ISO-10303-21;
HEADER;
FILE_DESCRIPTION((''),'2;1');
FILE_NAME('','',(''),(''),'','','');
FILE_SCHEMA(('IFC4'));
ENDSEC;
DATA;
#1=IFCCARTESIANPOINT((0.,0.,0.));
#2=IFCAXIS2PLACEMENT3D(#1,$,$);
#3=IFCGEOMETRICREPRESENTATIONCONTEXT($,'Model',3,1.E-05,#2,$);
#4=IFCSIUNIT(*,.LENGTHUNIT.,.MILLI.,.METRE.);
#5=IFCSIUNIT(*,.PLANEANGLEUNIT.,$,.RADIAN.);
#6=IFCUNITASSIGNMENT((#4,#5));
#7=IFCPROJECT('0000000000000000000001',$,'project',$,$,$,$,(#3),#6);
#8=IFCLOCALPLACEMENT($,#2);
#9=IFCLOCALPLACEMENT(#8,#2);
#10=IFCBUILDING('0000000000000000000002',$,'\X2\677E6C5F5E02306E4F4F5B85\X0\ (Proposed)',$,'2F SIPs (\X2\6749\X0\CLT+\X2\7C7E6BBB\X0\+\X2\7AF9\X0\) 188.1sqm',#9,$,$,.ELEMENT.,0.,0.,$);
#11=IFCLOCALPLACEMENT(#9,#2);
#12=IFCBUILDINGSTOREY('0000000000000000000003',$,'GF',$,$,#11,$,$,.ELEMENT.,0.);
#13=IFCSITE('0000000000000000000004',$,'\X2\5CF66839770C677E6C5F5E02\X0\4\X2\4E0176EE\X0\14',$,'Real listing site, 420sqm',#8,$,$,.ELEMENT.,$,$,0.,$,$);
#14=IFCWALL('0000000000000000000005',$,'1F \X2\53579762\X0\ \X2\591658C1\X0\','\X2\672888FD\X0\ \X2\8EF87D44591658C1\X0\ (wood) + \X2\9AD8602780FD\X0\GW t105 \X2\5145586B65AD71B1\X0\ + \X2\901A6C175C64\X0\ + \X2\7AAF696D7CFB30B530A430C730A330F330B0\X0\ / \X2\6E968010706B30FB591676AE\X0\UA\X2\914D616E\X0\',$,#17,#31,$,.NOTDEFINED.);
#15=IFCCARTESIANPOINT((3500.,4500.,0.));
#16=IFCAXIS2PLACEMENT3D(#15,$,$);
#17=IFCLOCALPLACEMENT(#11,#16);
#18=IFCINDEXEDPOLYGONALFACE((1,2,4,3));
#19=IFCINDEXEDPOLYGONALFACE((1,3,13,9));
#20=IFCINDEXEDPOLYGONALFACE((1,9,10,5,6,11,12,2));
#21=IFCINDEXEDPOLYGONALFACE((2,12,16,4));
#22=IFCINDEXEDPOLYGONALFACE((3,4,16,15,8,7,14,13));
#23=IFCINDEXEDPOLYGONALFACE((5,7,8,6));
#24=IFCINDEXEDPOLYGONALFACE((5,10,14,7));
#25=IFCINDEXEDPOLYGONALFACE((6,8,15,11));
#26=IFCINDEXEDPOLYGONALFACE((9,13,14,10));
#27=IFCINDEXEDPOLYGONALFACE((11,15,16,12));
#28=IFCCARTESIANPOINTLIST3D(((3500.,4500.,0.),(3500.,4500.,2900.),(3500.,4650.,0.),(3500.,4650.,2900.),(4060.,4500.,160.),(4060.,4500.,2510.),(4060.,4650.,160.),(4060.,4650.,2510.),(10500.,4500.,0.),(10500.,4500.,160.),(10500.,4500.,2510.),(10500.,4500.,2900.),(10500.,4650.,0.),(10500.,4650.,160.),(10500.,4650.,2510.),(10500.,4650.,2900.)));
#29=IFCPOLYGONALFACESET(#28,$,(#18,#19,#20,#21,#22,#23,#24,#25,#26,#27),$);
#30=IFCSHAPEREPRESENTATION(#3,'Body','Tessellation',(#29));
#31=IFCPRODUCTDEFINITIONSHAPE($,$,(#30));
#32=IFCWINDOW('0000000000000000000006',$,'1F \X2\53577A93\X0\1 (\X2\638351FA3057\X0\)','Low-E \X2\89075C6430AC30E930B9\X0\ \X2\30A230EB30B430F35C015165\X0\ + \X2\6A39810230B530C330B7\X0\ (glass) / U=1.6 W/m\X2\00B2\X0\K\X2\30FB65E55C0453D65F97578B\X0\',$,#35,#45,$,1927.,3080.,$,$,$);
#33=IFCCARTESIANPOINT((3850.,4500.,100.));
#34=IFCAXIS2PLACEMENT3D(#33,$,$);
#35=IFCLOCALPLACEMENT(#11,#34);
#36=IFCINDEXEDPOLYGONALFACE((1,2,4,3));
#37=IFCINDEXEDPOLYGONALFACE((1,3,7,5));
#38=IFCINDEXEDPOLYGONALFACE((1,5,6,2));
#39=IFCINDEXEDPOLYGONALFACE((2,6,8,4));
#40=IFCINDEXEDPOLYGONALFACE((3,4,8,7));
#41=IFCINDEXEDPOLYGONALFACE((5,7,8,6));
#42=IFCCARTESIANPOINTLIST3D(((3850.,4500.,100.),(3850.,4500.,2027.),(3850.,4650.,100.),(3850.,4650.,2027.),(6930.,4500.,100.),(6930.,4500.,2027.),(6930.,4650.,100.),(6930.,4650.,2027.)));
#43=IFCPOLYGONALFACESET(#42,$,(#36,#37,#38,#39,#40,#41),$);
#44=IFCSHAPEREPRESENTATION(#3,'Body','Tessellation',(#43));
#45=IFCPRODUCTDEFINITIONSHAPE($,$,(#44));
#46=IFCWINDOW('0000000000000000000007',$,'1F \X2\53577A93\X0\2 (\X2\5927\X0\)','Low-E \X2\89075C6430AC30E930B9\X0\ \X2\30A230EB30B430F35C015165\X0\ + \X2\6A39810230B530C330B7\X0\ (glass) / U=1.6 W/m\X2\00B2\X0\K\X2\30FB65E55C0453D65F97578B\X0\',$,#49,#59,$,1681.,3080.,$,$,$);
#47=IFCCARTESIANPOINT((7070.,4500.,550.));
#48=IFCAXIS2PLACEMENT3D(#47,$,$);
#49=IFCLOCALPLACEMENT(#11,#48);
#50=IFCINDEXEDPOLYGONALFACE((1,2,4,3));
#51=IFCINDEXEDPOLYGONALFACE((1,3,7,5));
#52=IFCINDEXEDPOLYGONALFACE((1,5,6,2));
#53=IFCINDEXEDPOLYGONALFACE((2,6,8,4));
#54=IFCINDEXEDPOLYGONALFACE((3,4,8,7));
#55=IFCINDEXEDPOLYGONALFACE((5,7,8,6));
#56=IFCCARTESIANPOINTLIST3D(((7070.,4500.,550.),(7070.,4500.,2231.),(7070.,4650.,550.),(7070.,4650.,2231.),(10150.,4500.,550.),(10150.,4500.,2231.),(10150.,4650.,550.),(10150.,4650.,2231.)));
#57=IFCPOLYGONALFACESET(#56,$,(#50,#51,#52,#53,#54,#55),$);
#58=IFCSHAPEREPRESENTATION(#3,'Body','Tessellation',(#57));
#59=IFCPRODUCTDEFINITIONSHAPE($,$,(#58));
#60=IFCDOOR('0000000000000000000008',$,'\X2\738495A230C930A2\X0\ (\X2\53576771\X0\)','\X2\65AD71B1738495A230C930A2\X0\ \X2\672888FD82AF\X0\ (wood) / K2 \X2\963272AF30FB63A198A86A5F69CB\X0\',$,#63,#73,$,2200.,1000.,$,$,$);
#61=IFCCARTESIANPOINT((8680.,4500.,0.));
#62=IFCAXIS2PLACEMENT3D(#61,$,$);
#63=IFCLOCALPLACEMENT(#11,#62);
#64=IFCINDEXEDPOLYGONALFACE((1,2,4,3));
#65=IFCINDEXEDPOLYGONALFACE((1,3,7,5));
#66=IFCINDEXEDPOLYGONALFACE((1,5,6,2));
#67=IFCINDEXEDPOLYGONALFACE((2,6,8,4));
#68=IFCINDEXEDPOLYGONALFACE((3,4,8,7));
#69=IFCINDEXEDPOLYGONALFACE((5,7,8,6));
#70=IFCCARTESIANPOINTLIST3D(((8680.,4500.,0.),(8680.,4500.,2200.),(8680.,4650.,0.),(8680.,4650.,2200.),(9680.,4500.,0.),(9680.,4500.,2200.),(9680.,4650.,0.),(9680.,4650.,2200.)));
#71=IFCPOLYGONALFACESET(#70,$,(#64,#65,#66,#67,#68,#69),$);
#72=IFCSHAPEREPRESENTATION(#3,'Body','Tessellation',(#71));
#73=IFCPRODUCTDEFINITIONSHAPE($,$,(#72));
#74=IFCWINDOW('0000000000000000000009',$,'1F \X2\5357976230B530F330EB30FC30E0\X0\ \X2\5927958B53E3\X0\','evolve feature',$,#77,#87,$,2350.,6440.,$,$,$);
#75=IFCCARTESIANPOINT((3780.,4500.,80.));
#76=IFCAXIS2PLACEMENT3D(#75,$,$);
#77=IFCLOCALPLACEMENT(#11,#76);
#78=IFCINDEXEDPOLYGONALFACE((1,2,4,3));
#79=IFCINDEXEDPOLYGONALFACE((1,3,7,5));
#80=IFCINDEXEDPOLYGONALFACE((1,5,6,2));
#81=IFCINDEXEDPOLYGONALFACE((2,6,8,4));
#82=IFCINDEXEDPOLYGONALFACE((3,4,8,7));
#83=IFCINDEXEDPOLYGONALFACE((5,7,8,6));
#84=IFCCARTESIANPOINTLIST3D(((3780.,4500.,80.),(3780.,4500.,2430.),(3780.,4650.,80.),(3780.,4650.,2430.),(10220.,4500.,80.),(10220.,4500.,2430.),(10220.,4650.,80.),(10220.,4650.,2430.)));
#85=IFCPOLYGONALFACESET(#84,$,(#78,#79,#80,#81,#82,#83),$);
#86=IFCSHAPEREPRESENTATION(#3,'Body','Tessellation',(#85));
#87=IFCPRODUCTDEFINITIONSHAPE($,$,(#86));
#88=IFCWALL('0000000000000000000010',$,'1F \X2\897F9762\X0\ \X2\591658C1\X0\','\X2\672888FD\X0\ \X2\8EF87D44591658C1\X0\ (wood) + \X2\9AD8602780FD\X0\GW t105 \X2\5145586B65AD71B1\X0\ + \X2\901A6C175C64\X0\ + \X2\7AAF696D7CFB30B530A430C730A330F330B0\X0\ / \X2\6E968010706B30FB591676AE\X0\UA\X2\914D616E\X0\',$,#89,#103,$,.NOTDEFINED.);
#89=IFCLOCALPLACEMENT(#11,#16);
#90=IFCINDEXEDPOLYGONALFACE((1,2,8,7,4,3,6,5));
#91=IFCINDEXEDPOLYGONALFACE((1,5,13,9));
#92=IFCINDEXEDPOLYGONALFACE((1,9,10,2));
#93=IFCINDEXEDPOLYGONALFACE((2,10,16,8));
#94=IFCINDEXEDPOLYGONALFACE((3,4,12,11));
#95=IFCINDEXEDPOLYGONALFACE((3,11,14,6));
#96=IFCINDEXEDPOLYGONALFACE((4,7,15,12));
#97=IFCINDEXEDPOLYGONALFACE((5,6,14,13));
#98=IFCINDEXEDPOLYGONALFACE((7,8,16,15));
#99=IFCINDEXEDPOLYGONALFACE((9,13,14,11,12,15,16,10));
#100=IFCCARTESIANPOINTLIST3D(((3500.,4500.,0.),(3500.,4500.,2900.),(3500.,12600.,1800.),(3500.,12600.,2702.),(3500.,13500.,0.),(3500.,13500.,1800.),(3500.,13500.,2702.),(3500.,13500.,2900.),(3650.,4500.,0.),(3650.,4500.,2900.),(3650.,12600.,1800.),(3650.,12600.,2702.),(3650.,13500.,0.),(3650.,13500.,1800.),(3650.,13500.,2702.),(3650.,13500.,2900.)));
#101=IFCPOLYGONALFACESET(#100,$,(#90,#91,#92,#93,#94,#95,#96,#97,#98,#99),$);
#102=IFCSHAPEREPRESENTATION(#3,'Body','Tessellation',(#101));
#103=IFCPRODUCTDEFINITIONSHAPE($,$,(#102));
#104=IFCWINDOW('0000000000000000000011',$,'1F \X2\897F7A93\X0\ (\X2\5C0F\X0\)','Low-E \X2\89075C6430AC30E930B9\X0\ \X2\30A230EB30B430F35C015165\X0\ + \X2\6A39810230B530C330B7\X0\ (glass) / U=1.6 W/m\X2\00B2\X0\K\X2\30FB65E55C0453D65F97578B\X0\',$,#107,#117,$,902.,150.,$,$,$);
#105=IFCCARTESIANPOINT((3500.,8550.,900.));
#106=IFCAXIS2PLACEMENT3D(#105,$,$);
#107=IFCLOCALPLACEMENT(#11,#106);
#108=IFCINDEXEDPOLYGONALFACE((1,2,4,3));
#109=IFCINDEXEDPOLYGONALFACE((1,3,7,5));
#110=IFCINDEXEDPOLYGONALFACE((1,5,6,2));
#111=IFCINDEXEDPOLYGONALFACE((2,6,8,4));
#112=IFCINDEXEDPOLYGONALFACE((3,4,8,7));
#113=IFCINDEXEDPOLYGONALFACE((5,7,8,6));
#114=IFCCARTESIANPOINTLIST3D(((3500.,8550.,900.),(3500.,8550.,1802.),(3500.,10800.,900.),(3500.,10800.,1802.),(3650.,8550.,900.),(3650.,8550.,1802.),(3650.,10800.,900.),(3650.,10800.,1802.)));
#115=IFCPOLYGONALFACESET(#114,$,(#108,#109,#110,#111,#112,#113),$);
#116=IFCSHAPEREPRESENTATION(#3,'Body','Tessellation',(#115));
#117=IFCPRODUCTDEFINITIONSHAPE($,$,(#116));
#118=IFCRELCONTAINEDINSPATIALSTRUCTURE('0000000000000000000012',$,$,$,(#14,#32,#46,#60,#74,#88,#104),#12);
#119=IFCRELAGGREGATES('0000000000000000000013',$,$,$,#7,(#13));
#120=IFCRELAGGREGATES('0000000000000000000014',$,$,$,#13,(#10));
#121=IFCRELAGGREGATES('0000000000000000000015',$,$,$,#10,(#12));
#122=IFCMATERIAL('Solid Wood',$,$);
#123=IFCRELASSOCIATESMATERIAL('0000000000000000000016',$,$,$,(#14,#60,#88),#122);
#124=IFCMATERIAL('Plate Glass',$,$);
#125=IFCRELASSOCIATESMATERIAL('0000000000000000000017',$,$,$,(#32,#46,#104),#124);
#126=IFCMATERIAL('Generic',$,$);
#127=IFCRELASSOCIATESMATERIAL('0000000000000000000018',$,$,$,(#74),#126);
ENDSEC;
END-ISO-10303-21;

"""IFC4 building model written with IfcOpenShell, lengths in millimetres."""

from ifc_helpers import new_model, si_unit, frame, frame_2d, origin, place, context, project, spatial, rectangle, extrude, material, element, fill, save


model = new_model("IFC4")

# Units and contexts
model_context = context("Model", 3, precision=1e-05, world=origin())
ifc_project = project(units=[si_unit("LENGTHUNIT", "METRE", prefix="MILLI"), si_unit("PLANEANGLEUNIT", "RADIAN")], contexts=[model_context])

# Site, building, storey
site_placement = place(None, origin())
site = spatial("IfcSite", under=ifc_project, at=site_placement, Name="島根県松江市4丁目14", ObjectType="Real listing site, 420sqm", CompositionType="ELEMENT", RefElevation=0.0)
building_placement = place(site_placement, origin())
building = spatial("IfcBuilding", under=site, at=building_placement, Name="松江市の住宅 (Proposed)", ObjectType="2F SIPs (杉CLT+籾殻+竹) 188.1sqm", CompositionType="ELEMENT", ElevationOfRefHeight=0.0, ElevationOfTerrain=0.0)
storey_placement = place(building_placement, origin())
storey = spatial("IfcBuildingStorey", under=building, at=storey_placement, Name="GF", CompositionType="ELEMENT", Elevation=0.0)

# Shared definitions
ifc_material_1 = material(Name="Solid Wood")
ifc_material_2 = material(Name="Generic")

# Wall, openings, windows, door
wall_1_placement = place(storey_placement, frame((3500.0, 4500.0, 0.0)))
wall_1 = element("IfcWall", 1, at=wall_1_placement, inside=storey, material=ifc_material_1, Name="1F 南面 外壁", Description="木製 軸組外壁 (wood) + 高性能GW t105 充填断熱 + 通気層 + 窯業系サイディング / 準耐火・外皮UA配慮", PredefinedType="NOTDEFINED", context=model_context, shape_type="SweptSolid", body=[
    extrude(rectangle(XDim=7000.0, YDim=150.0, at=frame_2d((3500.0, 75.0))), frame((3500.0, 4500.0, 0.0)), (0.0, 0.0, 1.0), 2900.0),
])
opening_1_placement = place(storey_placement, frame((3850.0, 4500.0, 100.0)))
opening_1 = element("IfcOpeningElement", 2, at=opening_1_placement, cuts=wall_1, PredefinedType="NOTDEFINED", context=model_context, shape_type="SweptSolid", body=[
    extrude(rectangle(XDim=3080.0, YDim=150.0, at=frame_2d((1540.0, 75.0))), frame((3850.0, 4500.0, 100.0)), (0.0, 0.0, 1.0), 1927.0),
])
opening_2_placement = place(storey_placement, frame((7070.0, 4500.0, 550.0)))
opening_2 = element("IfcOpeningElement", 3, at=opening_2_placement, cuts=wall_1, PredefinedType="NOTDEFINED", context=model_context, shape_type="SweptSolid", body=[
    extrude(rectangle(XDim=3080.0, YDim=150.0, at=frame_2d((1540.0, 75.0))), frame((7070.0, 4500.0, 550.0)), (0.0, 0.0, 1.0), 1681.0),
])
opening_3_placement = place(storey_placement, frame((8680.0, 4500.0, 0.0)))
opening_3 = element("IfcOpeningElement", 4, at=opening_3_placement, cuts=wall_1, PredefinedType="NOTDEFINED", context=model_context, shape_type="SweptSolid", body=[
    extrude(rectangle(XDim=1000.0, YDim=150.0, at=frame_2d((500.0, 75.0))), frame((8680.0, 4500.0, 0.0)), (0.0, 0.0, 1.0), 2200.0),
])
opening_4_placement = place(storey_placement, frame((3780.0, 4500.0, 80.0)))
opening_4 = element("IfcOpeningElement", 5, at=opening_4_placement, cuts=wall_1, PredefinedType="NOTDEFINED", context=model_context, shape_type="SweptSolid", body=[
    extrude(rectangle(XDim=6440.0, YDim=150.0, at=frame_2d((3220.0, 75.0))), frame((3780.0, 4500.0, 80.0)), (0.0, 0.0, 1.0), 2350.0),
])
ifc_material_3 = material(Name="Plate Glass")
window_1_placement = place(storey_placement, frame((3850.0, 4500.0, 100.0)))
window_1 = element("IfcWindow", 6, at=window_1_placement, inside=storey, material=ifc_material_3, Name="1F 南窓1 (掃出し)", Description="Low-E 複層ガラス アルゴン封入 + 樹脂サッシ (glass) / U=1.6 W/m²K・日射取得型", OverallHeight=1927.0, OverallWidth=3080.0, context=model_context, shape_type="SweptSolid", body=[
    extrude(rectangle(XDim=3080.0, YDim=150.0, at=frame_2d((1540.0, 75.0))), frame((3850.0, 4500.0, 100.0)), (0.0, 0.0, 1.0), 1927.0),
])
fill(opening_1, window_1)
window_2_placement = place(storey_placement, frame((7070.0, 4500.0, 550.0)))
window_2 = element("IfcWindow", 7, at=window_2_placement, inside=storey, material=ifc_material_3, Name="1F 南窓2 (大)", Description="Low-E 複層ガラス アルゴン封入 + 樹脂サッシ (glass) / U=1.6 W/m²K・日射取得型", OverallHeight=1681.0, OverallWidth=3080.0, context=model_context, shape_type="SweptSolid", body=[
    extrude(rectangle(XDim=3080.0, YDim=150.0, at=frame_2d((1540.0, 75.0))), frame((7070.0, 4500.0, 550.0)), (0.0, 0.0, 1.0), 1681.0),
])
fill(opening_2, window_2)
door_placement = place(storey_placement, frame((8680.0, 4500.0, 0.0)))
door = element("IfcDoor", 8, at=door_placement, inside=storey, material=ifc_material_1, Name="玄関ドア (南東)", Description="断熱玄関ドア 木製芯 (wood) / K2 防犯・採風機構", OverallHeight=2200.0, OverallWidth=1000.0, context=model_context, shape_type="SweptSolid", body=[
    extrude(rectangle(XDim=1000.0, YDim=150.0, at=frame_2d((500.0, 75.0))), frame((8680.0, 4500.0, 0.0)), (0.0, 0.0, 1.0), 2200.0),
])
fill(opening_3, door)
window_3_placement = place(storey_placement, frame((3780.0, 4500.0, 80.0)))
window_3 = element("IfcWindow", 9, at=window_3_placement, inside=storey, material=ifc_material_2, Name="1F 南面サンルーム 大開口", Description="evolve feature", OverallHeight=2350.0, OverallWidth=6440.0, context=model_context, shape_type="SweptSolid", body=[
    extrude(rectangle(XDim=6440.0, YDim=150.0, at=frame_2d((3220.0, 75.0))), frame((3780.0, 4500.0, 80.0)), (0.0, 0.0, 1.0), 2350.0),
])
fill(opening_4, window_3)

# Wall, opening, window
wall_2_placement = place(storey_placement, frame((3500.0, 4500.0, 0.0)))
wall_2 = element("IfcWall", 10, at=wall_2_placement, inside=storey, material=ifc_material_1, Name="1F 西面 外壁", Description="木製 軸組外壁 (wood) + 高性能GW t105 充填断熱 + 通気層 + 窯業系サイディング / 準耐火・外皮UA配慮", PredefinedType="NOTDEFINED", context=model_context, shape_type="SweptSolid", body=[
    extrude(rectangle(XDim=150.0, YDim=9000.0, at=frame_2d((75.0, 4500.0))), frame((3500.0, 4500.0, 0.0)), (0.0, 0.0, 1.0), 2900.0),
])
opening_5_placement = place(storey_placement, frame((3500.0, 8550.0, 900.0)))
opening_5 = element("IfcOpeningElement", 11, at=opening_5_placement, cuts=wall_2, PredefinedType="NOTDEFINED", context=model_context, shape_type="SweptSolid", body=[
    extrude(rectangle(XDim=150.0, YDim=2250.0, at=frame_2d((75.0, 1125.0))), frame((3500.0, 8550.0, 900.0)), (0.0, 0.0, 1.0), 902.0),
])
window_4_placement = place(storey_placement, frame((3500.0, 8550.0, 900.0)))
window_4 = element("IfcWindow", 12, at=window_4_placement, inside=storey, material=ifc_material_3, Name="1F 西窓 (小)", Description="Low-E 複層ガラス アルゴン封入 + 樹脂サッシ (glass) / U=1.6 W/m²K・日射取得型", OverallHeight=902.0, OverallWidth=150.0, context=model_context, shape_type="SweptSolid", body=[
    extrude(rectangle(XDim=150.0, YDim=2250.0, at=frame_2d((75.0, 1125.0))), frame((3500.0, 8550.0, 900.0)), (0.0, 0.0, 1.0), 902.0),
])
fill(opening_5, window_4)

save(model, "model.ifc")
